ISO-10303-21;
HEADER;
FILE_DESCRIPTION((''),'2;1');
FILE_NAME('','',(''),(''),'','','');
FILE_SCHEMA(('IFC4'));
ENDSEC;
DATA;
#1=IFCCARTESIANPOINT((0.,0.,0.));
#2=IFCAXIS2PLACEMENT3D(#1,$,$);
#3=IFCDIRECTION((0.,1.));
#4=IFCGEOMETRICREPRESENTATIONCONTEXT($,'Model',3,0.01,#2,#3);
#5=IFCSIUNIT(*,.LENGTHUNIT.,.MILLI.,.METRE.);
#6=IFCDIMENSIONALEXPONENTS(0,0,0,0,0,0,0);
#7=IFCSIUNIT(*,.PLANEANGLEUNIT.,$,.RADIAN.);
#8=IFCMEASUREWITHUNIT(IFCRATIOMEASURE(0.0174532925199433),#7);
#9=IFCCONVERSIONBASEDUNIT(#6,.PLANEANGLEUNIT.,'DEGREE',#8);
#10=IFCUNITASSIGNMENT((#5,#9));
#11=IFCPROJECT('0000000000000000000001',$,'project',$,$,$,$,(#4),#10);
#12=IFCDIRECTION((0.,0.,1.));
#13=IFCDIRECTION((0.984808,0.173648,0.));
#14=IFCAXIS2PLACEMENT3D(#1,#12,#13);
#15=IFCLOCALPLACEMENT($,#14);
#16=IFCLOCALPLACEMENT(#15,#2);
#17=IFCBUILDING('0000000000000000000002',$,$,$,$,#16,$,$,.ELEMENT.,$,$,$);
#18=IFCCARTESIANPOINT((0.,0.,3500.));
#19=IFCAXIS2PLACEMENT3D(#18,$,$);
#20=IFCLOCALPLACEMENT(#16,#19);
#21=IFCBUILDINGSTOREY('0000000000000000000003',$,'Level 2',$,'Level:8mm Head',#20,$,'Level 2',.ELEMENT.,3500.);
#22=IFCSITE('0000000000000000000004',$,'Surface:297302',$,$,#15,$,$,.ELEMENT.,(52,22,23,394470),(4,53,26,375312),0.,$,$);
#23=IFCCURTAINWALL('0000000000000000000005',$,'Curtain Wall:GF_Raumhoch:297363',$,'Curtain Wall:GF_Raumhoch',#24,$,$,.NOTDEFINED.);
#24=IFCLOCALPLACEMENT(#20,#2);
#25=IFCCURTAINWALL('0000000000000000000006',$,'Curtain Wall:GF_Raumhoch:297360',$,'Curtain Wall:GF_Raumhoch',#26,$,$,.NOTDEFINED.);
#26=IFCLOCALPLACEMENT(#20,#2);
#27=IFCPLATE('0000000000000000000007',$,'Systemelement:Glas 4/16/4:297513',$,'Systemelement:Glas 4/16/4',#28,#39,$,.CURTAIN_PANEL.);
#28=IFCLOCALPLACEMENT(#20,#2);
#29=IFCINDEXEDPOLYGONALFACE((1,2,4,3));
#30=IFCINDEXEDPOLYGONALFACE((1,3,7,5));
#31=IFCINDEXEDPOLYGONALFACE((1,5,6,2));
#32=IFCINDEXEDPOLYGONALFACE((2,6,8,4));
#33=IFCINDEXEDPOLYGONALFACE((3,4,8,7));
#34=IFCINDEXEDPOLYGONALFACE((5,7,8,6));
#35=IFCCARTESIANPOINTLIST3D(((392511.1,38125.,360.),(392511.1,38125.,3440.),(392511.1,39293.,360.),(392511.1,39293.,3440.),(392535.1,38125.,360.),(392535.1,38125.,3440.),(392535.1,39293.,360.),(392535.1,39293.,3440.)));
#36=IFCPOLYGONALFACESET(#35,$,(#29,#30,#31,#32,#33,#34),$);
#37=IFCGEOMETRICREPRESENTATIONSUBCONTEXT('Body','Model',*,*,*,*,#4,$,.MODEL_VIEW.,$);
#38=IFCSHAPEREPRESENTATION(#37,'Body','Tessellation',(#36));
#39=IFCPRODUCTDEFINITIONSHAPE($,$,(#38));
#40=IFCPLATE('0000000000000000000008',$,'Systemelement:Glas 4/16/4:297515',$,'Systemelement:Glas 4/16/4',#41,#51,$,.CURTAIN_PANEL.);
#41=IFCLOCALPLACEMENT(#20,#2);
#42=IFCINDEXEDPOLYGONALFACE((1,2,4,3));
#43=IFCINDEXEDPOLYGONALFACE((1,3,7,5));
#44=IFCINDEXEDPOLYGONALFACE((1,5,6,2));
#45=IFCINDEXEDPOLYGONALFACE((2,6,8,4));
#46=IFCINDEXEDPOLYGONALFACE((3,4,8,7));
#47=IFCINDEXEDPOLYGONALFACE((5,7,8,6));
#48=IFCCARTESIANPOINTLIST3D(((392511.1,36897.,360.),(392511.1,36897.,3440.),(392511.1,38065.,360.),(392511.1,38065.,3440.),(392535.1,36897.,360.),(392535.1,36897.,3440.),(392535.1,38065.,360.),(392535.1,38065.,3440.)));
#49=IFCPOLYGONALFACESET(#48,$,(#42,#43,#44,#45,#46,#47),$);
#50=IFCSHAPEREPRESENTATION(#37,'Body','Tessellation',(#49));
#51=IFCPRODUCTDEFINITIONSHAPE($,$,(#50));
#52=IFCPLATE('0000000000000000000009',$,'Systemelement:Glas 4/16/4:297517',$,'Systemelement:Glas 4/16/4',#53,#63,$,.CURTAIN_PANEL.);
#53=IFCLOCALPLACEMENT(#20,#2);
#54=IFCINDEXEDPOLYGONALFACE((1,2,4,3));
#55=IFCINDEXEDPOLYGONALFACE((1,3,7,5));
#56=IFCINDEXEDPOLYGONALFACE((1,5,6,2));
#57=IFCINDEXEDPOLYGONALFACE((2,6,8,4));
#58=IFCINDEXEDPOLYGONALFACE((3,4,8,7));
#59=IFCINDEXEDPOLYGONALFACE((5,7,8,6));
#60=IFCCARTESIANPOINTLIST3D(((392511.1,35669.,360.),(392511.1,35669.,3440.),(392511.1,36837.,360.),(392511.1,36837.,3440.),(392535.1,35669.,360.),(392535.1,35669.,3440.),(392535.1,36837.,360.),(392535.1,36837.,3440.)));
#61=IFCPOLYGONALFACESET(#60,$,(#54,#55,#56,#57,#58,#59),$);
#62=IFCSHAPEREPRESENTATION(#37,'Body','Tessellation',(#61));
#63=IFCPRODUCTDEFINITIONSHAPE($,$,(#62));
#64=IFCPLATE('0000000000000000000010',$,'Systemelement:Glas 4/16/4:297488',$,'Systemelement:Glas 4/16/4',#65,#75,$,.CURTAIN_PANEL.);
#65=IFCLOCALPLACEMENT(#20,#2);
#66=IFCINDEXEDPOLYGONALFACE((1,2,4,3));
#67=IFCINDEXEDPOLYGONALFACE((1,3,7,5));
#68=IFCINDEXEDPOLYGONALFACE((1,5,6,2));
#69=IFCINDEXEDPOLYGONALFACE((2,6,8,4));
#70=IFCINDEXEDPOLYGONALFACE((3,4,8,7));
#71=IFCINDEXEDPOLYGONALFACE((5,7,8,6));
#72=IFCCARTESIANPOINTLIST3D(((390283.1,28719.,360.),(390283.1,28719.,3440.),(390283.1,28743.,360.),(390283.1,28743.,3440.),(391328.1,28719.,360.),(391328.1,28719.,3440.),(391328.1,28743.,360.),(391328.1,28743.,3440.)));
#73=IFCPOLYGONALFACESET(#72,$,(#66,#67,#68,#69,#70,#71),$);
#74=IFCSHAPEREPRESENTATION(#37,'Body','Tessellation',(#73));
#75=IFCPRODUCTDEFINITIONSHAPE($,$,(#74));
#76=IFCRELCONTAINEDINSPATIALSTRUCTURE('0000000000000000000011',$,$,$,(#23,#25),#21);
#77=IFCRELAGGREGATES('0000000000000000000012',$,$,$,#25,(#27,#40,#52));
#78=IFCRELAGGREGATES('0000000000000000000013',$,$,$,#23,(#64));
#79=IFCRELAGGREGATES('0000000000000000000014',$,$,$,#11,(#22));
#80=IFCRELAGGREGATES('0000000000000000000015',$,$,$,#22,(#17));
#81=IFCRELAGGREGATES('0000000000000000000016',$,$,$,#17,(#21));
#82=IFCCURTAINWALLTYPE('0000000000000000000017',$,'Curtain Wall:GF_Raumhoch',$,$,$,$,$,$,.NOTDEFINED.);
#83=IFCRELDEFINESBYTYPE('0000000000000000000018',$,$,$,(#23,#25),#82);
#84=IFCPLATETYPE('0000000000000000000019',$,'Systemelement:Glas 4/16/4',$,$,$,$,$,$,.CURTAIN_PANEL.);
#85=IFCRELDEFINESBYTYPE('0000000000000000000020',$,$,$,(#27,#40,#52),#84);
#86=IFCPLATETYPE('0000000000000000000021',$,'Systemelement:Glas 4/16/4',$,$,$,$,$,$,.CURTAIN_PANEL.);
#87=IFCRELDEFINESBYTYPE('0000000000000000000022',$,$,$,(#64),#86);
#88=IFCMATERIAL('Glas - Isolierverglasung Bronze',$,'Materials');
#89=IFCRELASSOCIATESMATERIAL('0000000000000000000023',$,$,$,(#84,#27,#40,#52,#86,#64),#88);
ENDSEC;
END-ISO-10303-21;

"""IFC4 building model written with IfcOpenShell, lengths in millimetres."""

from ifc_helpers import new_model, entity, si_unit, converted_unit, direction, frame, origin, place, context, subcontext, project, spatial, indexed_curve, outline, extrude, source, transform, mapped, material, type_object, type_shapes, element, aggregate, save


model = new_model("IFC4")

# Units and contexts
model_context = context("Model", 3, precision=0.01, world=origin(), true_north=direction((0.0, 1.0)))
body_context = subcontext(model_context, "Body", "Model", "MODEL_VIEW")
ifc_project = project(units=[si_unit("LENGTHUNIT", "METRE", prefix="MILLI"), converted_unit("PLANEANGLEUNIT", "DEGREE", entity("IfcRatioMeasure", 0.0174532925199433), si_unit("PLANEANGLEUNIT", "RADIAN"), dimensions=[0, 0, 0, 0, 0, 0, 0])], contexts=[model_context])

# Site, building, storey
site_placement = place(None, frame((0.0, 0.0, 0.0), z_axis=(0.0, 0.0, 1.0), x_axis=(0.984808, 0.173648, 0.0)))
site = spatial("IfcSite", under=ifc_project, at=site_placement, Name="Surface:297302", CompositionType="ELEMENT", RefLatitude=(52, 22, 23, 394470), RefLongitude=(4, 53, 26, 375312), RefElevation=0.0)
building_placement = place(site_placement, origin())
building = spatial("IfcBuilding", under=site, at=building_placement, CompositionType="ELEMENT")
storey_placement = place(building_placement, frame((0.0, 0.0, 3500.0)))
storey = spatial("IfcBuildingStorey", under=building, at=storey_placement, Name="Level 2", ObjectType="Level:8mm Head", LongName="Level 2", CompositionType="ELEMENT", Elevation=3500.0)

# Shared definitions
curtain_wall_type = type_object("IfcCurtainWallType", Name="Curtain Wall:GF_Raumhoch", PredefinedType="NOTDEFINED")

# Curtain wall
curtain_wall_1_placement = place(storey_placement, frame((0.0, 0.0, -3500.0)))
curtain_wall_1 = element("IfcCurtainWall", 1, at=curtain_wall_1_placement, inside=storey, type_object=curtain_wall_type, Name="Curtain Wall:GF_Raumhoch:297363", ObjectType="Curtain Wall:GF_Raumhoch", PredefinedType="NOTDEFINED")

# Curtain wall
curtain_wall_2_placement = place(storey_placement, frame((0.0, 0.0, -3500.0)))
curtain_wall_2 = element("IfcCurtainWall", 2, at=curtain_wall_2_placement, inside=storey, type_object=curtain_wall_type, Name="Curtain Wall:GF_Raumhoch:297360", ObjectType="Curtain Wall:GF_Raumhoch", PredefinedType="NOTDEFINED")

# Plates
ifc_material_1 = material(Name="Glas - Isolierverglasung Bronze", Category="Materials")
plate_type_1 = type_object("IfcPlateType", Name="Systemelement:Glas 4/16/4", PredefinedType="CURTAIN_PANEL", material=ifc_material_1)
shared_shape_1 = source(origin(), body_context, "Body", "SweptSolid", [
    extrude(outline(indexed_curve([(-12.0, -584.0), (12.0, -584.0), (12.0, 584.0), (-12.0, 584.0), (-12.0, -584.0)], self_intersect=False)), frame((0.0, 0.0, 0.0), z_axis=(0.0, 0.0, 1.0), x_axis=(0.0, 1.0, 0.0)), (0.0, 0.0, 1.0), 3080.0),
])
type_shapes(plate_type_1, [shared_shape_1])
plate_1_placement = place(curtain_wall_2_placement, frame((392523.1, 38709.0, 3860.0), z_axis=(0.0, 0.0, 1.0), x_axis=(0.0, -1.0, 0.0)))
plate_1 = element("IfcPlate", 3, at=plate_1_placement, type_object=plate_type_1, material=ifc_material_1, Name="Systemelement:Glas 4/16/4:297513", ObjectType="Systemelement:Glas 4/16/4", PredefinedType="CURTAIN_PANEL", context=body_context, shape_type="MappedRepresentation", body=[
    mapped(shared_shape_1, transform((0.0, 0.0, 0.0), scale=1.0)),
])
plate_2_placement = place(curtain_wall_2_placement, frame((392523.1, 37481.0, 3860.0), z_axis=(0.0, 0.0, 1.0), x_axis=(0.0, -1.0, 0.0)))
plate_2 = element("IfcPlate", 4, at=plate_2_placement, type_object=plate_type_1, material=ifc_material_1, Name="Systemelement:Glas 4/16/4:297515", ObjectType="Systemelement:Glas 4/16/4", PredefinedType="CURTAIN_PANEL", context=body_context, shape_type="MappedRepresentation", body=[
    mapped(shared_shape_1, transform((0.0, 0.0, 0.0), scale=1.0)),
])
plate_3_placement = place(curtain_wall_2_placement, frame((392523.1, 36253.0, 3860.0), z_axis=(0.0, 0.0, 1.0), x_axis=(0.0, -1.0, 0.0)))
plate_3 = element("IfcPlate", 5, at=plate_3_placement, type_object=plate_type_1, material=ifc_material_1, Name="Systemelement:Glas 4/16/4:297517", ObjectType="Systemelement:Glas 4/16/4", PredefinedType="CURTAIN_PANEL", context=body_context, shape_type="MappedRepresentation", body=[
    mapped(shared_shape_1, transform((0.0, 0.0, 0.0), scale=1.0)),
])
aggregate(curtain_wall_2, [plate_1, plate_2, plate_3])
plate_type_2 = type_object("IfcPlateType", Name="Systemelement:Glas 4/16/4", PredefinedType="CURTAIN_PANEL", material=ifc_material_1)
shared_shape_2 = source(origin(), body_context, "Body", "SweptSolid", [
    extrude(outline(indexed_curve([(-12.0, -522.5), (12.0, -522.5), (12.0, 522.5), (-12.0, 522.5), (-12.0, -522.5)], self_intersect=False)), frame((0.0, 0.0, 0.0), z_axis=(0.0, 0.0, 1.0), x_axis=(0.0, 1.0, 0.0)), (0.0, 0.0, 1.0), 3080.0),
])
type_shapes(plate_type_2, [shared_shape_2])
plate_4_placement = place(curtain_wall_1_placement, frame((390805.6, 28731.0, 3860.0), z_axis=(0.0, 0.0, 1.0), x_axis=(-1.0, 0.0, 0.0)))
plate_4 = element("IfcPlate", 6, at=plate_4_placement, type_object=plate_type_2, material=ifc_material_1, Name="Systemelement:Glas 4/16/4:297488", ObjectType="Systemelement:Glas 4/16/4", PredefinedType="CURTAIN_PANEL", context=body_context, shape_type="MappedRepresentation", body=[
    mapped(shared_shape_2, transform((0.0, 0.0, 0.0), scale=1.0)),
])
aggregate(curtain_wall_1, [plate_4])

save(model, "model.ifc")
